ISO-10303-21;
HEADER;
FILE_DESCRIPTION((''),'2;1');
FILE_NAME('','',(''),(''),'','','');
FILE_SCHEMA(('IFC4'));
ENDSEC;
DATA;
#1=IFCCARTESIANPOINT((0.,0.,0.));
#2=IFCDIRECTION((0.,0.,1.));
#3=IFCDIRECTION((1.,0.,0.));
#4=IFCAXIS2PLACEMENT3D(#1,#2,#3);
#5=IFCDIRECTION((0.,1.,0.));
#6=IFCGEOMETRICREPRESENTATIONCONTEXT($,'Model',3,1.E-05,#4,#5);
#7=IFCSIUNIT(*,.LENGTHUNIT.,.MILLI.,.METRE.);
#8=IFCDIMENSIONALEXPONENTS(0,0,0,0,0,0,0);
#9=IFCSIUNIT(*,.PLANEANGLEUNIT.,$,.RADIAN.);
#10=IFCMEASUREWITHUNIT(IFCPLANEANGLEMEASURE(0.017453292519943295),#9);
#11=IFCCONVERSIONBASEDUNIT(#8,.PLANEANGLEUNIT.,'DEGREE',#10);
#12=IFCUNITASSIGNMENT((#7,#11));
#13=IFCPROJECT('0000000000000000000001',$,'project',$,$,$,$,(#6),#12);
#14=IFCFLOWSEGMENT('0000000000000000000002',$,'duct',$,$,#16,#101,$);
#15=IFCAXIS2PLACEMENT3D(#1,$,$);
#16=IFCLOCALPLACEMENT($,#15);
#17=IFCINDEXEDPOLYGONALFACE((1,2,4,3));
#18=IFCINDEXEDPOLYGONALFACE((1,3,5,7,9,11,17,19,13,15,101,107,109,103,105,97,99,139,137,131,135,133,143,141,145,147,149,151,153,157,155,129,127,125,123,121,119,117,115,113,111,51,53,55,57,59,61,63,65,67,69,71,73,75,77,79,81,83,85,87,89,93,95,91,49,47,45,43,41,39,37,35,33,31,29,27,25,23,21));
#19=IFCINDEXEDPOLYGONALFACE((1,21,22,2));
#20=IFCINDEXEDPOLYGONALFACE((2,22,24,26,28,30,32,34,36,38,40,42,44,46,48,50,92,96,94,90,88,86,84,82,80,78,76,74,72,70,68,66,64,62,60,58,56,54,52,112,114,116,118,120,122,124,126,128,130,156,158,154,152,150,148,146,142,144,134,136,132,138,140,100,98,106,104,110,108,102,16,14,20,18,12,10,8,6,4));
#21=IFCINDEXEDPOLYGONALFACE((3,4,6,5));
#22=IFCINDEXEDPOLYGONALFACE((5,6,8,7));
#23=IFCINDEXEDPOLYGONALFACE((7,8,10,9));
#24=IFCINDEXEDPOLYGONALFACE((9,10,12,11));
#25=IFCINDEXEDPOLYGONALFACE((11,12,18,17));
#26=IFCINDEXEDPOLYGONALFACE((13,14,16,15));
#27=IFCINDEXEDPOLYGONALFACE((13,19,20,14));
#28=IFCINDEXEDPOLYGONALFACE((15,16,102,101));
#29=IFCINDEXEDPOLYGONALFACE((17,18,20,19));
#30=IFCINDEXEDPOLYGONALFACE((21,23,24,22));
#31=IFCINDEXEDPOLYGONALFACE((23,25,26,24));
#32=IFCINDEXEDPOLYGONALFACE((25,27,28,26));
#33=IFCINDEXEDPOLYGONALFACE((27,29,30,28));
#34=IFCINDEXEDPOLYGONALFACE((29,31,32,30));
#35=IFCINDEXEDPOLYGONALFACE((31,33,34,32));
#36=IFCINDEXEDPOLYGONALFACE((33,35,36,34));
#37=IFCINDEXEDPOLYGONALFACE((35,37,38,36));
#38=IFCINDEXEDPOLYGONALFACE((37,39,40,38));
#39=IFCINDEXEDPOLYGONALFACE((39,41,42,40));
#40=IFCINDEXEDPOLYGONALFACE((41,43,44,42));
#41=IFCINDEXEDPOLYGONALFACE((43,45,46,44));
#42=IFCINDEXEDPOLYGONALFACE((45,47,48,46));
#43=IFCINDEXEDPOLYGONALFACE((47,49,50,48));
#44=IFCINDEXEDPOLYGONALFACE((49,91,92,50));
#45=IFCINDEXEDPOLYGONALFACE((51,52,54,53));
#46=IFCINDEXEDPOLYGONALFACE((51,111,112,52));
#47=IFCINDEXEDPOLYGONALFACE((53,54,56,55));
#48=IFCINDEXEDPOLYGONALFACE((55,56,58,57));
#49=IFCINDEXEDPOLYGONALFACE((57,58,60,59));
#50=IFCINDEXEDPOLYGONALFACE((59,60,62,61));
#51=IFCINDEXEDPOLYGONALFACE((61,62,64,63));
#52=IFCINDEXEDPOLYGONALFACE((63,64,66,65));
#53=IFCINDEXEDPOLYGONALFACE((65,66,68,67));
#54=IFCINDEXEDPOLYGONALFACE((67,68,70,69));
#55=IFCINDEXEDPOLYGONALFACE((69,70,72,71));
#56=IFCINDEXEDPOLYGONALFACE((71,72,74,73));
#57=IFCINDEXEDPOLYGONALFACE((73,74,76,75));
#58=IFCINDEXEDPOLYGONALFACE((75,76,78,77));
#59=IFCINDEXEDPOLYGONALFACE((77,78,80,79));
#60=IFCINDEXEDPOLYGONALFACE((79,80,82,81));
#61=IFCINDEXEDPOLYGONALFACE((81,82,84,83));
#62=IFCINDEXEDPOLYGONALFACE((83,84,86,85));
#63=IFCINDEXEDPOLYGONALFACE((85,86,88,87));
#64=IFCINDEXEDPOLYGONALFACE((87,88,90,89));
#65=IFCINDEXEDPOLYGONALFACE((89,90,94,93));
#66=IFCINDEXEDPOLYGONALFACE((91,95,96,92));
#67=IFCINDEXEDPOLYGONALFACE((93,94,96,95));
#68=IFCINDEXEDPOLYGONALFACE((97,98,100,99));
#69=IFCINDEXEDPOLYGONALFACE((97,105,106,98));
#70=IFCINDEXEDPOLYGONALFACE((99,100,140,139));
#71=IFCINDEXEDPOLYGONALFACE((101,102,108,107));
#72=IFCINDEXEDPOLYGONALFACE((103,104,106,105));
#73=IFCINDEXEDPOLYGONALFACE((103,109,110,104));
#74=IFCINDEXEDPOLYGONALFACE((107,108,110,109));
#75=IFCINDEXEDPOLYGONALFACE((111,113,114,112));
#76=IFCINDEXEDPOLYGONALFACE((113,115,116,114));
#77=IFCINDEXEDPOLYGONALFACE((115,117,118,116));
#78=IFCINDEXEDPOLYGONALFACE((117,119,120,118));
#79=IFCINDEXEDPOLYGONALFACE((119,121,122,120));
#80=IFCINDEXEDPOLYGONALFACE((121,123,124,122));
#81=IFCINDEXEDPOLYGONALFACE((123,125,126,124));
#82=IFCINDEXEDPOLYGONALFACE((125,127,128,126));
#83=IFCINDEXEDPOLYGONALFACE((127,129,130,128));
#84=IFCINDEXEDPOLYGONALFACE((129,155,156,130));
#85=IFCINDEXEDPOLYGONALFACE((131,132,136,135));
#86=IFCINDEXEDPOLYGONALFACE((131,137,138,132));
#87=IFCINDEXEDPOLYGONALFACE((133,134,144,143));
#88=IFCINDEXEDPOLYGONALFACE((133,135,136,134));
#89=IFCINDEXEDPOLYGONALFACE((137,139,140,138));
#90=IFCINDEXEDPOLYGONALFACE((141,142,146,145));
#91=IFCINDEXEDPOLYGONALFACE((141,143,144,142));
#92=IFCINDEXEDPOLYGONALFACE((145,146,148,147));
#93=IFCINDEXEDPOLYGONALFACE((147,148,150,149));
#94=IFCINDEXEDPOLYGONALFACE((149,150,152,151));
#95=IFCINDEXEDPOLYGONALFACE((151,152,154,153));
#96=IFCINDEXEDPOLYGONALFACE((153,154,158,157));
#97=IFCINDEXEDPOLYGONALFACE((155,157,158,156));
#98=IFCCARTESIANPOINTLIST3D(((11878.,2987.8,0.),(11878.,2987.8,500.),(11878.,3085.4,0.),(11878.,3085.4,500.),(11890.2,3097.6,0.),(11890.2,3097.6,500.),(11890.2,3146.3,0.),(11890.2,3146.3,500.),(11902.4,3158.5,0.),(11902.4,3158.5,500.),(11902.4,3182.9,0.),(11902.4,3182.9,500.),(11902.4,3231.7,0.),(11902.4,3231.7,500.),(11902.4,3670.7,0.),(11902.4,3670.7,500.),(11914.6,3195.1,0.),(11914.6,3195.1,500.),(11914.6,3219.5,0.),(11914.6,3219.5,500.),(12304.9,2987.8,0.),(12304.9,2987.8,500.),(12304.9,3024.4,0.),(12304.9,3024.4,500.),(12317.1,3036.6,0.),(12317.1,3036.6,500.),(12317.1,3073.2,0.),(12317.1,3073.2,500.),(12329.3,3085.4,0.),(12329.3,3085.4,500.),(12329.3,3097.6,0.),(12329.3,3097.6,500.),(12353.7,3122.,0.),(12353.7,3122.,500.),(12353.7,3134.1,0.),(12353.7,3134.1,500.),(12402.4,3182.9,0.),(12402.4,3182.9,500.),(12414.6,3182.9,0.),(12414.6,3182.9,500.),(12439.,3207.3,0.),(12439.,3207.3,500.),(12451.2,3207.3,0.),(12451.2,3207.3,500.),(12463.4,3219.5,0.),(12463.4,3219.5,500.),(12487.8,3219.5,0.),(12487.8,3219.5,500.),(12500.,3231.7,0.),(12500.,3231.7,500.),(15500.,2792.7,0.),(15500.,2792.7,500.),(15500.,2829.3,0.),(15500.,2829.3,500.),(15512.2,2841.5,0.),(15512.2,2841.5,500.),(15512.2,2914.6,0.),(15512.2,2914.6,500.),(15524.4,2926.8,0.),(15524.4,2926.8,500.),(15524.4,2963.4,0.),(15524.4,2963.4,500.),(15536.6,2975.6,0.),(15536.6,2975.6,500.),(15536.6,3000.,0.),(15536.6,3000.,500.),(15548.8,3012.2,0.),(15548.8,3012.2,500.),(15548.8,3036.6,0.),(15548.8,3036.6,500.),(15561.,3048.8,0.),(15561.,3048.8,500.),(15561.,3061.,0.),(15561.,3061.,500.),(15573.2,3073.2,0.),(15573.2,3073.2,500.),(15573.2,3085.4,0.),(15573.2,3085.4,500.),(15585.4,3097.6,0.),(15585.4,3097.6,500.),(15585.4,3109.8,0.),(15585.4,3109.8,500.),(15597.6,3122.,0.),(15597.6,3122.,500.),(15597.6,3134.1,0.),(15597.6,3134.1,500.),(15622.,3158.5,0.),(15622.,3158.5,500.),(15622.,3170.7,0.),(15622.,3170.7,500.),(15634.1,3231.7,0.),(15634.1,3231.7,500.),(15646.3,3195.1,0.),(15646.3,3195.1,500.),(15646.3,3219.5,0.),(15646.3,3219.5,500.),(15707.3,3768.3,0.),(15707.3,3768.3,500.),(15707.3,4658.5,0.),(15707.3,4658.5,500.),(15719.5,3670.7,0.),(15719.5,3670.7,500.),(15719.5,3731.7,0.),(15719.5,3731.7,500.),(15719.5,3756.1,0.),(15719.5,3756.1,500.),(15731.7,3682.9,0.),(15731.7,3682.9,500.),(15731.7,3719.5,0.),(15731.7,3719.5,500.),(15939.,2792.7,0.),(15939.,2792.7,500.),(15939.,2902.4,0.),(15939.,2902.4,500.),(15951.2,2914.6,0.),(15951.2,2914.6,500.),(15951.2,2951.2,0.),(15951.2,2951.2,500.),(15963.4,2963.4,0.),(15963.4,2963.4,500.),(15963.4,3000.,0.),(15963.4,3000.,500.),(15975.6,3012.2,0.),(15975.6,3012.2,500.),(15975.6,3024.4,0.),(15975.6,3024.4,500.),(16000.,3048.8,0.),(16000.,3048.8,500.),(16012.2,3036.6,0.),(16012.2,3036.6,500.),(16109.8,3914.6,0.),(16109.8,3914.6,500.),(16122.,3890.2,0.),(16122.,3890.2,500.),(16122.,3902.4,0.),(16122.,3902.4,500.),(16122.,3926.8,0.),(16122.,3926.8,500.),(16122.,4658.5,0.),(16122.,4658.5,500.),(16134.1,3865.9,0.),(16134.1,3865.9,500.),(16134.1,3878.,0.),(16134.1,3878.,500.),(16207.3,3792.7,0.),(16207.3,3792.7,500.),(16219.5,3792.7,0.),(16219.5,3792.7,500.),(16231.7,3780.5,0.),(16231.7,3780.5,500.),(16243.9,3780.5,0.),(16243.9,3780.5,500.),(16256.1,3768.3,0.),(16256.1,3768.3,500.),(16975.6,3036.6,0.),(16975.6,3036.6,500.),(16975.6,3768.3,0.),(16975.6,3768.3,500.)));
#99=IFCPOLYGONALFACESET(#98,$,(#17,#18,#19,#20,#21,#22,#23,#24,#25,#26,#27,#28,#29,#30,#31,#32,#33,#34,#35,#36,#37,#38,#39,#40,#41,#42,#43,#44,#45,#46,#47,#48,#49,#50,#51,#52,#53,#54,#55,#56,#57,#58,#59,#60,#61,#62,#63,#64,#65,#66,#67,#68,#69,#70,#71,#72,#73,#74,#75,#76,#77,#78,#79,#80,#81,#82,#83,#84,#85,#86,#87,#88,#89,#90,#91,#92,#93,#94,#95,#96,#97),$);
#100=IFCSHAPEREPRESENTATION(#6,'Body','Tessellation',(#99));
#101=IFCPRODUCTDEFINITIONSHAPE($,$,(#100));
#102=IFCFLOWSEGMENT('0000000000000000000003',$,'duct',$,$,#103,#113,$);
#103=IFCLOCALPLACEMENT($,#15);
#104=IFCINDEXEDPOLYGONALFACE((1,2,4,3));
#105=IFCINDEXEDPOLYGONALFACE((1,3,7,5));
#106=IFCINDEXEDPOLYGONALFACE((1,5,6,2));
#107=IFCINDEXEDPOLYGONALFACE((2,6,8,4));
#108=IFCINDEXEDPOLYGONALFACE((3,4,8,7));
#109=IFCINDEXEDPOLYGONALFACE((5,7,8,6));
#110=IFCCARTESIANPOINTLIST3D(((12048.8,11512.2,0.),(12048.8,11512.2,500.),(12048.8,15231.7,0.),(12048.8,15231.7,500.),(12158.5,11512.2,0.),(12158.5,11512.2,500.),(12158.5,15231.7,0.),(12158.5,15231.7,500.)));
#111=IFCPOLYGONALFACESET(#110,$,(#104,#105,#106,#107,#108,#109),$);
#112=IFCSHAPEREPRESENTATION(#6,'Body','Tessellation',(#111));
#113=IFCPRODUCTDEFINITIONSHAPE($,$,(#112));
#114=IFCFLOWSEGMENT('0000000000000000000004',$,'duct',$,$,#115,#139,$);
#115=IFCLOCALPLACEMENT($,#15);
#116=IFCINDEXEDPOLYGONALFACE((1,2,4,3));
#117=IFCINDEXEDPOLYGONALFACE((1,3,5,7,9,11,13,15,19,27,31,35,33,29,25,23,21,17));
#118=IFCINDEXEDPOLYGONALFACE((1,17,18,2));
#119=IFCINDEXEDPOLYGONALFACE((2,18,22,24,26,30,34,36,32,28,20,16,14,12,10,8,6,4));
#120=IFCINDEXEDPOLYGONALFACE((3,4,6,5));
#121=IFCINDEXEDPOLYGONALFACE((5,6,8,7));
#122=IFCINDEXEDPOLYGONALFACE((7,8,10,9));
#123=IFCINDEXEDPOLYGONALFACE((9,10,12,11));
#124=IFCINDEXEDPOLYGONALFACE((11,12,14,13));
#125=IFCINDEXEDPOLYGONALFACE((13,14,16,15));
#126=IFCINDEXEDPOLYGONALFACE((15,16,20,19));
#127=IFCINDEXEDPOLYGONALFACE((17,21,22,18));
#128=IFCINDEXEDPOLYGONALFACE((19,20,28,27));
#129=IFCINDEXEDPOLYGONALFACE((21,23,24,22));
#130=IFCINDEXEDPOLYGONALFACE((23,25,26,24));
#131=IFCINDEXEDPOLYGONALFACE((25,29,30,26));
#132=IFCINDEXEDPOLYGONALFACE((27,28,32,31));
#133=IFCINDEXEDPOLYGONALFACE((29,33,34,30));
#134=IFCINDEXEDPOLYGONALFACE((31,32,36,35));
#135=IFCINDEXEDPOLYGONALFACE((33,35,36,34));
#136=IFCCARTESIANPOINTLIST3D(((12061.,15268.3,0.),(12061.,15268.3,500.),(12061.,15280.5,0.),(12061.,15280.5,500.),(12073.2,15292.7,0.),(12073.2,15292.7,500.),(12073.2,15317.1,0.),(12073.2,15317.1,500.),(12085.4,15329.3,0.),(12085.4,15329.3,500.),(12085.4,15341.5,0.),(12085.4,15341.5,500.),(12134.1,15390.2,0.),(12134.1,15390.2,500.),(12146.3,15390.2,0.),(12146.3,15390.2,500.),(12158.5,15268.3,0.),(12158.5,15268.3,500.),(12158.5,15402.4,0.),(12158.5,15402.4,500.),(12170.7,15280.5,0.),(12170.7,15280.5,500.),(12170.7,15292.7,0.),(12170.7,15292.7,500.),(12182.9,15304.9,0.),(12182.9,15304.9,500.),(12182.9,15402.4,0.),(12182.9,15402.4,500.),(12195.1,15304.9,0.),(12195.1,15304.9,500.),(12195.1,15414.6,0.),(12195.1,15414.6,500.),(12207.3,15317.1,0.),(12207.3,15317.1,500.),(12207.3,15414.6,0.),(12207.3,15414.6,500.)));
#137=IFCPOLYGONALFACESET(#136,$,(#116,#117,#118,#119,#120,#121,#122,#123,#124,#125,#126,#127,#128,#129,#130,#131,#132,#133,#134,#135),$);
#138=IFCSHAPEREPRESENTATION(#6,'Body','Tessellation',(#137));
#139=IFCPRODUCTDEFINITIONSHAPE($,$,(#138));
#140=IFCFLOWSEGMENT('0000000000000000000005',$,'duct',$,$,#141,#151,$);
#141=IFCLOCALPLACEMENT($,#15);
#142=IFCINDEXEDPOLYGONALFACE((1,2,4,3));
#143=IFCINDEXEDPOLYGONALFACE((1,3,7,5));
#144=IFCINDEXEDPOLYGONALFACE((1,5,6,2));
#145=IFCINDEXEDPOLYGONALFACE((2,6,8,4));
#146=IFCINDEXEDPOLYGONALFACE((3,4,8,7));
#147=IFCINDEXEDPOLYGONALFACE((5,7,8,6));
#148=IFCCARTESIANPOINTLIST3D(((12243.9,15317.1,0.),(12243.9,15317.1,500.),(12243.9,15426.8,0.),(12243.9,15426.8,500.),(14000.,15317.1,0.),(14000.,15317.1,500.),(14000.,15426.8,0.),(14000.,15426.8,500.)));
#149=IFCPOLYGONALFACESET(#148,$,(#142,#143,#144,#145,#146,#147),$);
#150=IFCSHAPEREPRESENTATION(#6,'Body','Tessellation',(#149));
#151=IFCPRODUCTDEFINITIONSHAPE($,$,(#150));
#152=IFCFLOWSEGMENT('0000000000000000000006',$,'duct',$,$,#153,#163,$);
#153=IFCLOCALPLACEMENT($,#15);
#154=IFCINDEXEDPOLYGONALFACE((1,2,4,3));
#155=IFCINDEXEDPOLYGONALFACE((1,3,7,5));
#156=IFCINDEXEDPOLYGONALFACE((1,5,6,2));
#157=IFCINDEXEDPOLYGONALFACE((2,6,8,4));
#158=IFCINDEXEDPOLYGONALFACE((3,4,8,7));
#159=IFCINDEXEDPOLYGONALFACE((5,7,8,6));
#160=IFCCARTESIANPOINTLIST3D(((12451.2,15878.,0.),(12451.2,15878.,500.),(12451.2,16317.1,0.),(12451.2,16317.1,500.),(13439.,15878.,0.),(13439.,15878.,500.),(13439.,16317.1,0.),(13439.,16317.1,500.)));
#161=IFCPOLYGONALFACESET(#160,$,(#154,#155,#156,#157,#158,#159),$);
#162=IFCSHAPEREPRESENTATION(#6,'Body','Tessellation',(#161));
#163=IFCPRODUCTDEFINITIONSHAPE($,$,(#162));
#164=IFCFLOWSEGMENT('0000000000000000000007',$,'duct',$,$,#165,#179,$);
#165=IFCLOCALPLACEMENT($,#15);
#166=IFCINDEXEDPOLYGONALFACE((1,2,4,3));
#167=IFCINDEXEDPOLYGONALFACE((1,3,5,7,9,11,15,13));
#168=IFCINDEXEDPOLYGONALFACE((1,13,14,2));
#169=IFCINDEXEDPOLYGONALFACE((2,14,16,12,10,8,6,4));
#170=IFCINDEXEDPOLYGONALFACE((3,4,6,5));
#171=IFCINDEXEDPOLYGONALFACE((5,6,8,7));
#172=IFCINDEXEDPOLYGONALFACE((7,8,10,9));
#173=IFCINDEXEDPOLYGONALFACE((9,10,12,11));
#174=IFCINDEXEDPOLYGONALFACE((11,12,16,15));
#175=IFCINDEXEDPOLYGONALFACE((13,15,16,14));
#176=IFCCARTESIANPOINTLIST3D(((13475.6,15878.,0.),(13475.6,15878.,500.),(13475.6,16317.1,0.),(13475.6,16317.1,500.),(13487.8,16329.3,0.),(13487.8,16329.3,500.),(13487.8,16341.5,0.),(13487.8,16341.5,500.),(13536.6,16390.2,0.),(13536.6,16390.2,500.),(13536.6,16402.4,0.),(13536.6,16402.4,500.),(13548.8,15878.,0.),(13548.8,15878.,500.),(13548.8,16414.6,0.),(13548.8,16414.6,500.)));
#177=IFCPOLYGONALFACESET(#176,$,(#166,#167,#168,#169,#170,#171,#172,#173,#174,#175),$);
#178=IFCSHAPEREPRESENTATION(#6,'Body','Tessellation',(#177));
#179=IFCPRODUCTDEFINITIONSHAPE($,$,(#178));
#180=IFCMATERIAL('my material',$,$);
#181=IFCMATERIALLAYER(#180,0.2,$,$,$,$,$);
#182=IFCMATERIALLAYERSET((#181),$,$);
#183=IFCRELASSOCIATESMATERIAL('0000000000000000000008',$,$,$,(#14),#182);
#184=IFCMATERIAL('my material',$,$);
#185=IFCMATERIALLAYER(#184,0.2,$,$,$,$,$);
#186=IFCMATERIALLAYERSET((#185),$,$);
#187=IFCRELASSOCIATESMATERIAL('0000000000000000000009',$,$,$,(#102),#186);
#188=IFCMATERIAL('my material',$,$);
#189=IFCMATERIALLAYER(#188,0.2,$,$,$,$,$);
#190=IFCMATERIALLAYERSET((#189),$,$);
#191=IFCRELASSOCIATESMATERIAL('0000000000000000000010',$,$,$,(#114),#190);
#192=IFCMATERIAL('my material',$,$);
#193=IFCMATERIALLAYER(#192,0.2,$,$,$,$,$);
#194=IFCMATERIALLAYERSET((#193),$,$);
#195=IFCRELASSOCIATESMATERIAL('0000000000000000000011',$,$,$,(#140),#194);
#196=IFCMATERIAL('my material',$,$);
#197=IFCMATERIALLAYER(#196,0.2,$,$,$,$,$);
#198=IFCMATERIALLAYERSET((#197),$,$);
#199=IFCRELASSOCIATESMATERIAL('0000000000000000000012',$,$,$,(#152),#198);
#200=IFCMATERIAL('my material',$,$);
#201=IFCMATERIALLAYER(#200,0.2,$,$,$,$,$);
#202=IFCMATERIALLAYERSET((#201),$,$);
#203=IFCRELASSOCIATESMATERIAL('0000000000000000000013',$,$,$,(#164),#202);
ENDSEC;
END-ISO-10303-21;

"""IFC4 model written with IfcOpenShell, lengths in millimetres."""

from ifc_helpers import new_model, entity, si_unit, converted_unit, direction, origin_with_axes, place, context, project, polyline, outline, extrude, material, layer, layer_set, layer_usage, element, save


model = new_model("IFC4")

# Units and contexts
model_context = context("Model", 3, precision=1e-05, world=origin_with_axes(), true_north=direction((0.0, 1.0, 0.0)))
ifc_project = project(units=[si_unit("LENGTHUNIT", "METRE", prefix="MILLI"), converted_unit("PLANEANGLEUNIT", "DEGREE", entity("IfcPlaneAngleMeasure", 0.017453292519943295), si_unit("PLANEANGLEUNIT", "RADIAN"), dimensions=[0, 0, 0, 0, 0, 0, 0])], contexts=[model_context])

# Flow segments
ifc_material_1 = material(Name="my material")
ifc_layer_1 = layer(ifc_material_1, 0.2)
ifc_layer_set_1 = layer_set([ifc_layer_1])
ifc_layer_usage_1 = layer_usage(ifc_layer_set_1, "AXIS2", "POSITIVE", -0.1)
flow_segment_1_placement = place(None, origin_with_axes())
element("IfcFlowSegment", 1, at=flow_segment_1_placement, material=ifc_layer_usage_1, Name="duct", context=model_context, shape_type="SweptSolid", body=[
    extrude(outline(polyline([(11878.0, 2987.8), (12304.9, 2987.8), (12304.9, 3024.4), (12317.1, 3036.6), (12317.1, 3073.2), (12329.3, 3085.4), (12329.3, 3097.6), (12353.7, 3122.0), (12353.7, 3134.1), (12402.4, 3182.9), (12414.6, 3182.9), (12439.0, 3207.3), (12451.2, 3207.3), (12463.4, 3219.5), (12487.8, 3219.5), (12500.0, 3231.7), (15634.1, 3231.7), (15646.3, 3219.5), (15646.3, 3195.1), (15622.0, 3170.7), (15622.0, 3158.5), (15597.6, 3134.1), (15597.6, 3122.0), (15585.4, 3109.8), (15585.4, 3097.6), (15573.2, 3085.4), (15573.2, 3073.2), (15561.0, 3061.0), (15561.0, 3048.8), (15548.8, 3036.6), (15548.8, 3012.2), (15536.6, 3000.0), (15536.6, 2975.6), (15524.4, 2963.4), (15524.4, 2926.8), (15512.2, 2914.6), (15512.2, 2841.5), (15500.0, 2829.3), (15500.0, 2792.7), (15939.0, 2792.7), (15939.0, 2902.4), (15951.2, 2914.6), (15951.2, 2951.2), (15963.4, 2963.4), (15963.4, 3000.0), (15975.6, 3012.2), (15975.6, 3024.4), (16000.0, 3048.8), (16012.2, 3036.6), (16975.6, 3036.6), (16975.6, 3768.3), (16256.1, 3768.3), (16243.9, 3780.5), (16231.7, 3780.5), (16219.5, 3792.7), (16207.3, 3792.7), (16134.1, 3865.9), (16134.1, 3878.0), (16122.0, 3890.2), (16122.0, 3902.4), (16109.8, 3914.6), (16122.0, 3926.8), (16122.0, 4658.5), (15707.3, 4658.5), (15707.3, 3768.3), (15719.5, 3756.1), (15719.5, 3731.7), (15731.7, 3719.5), (15731.7, 3682.9), (15719.5, 3670.7), (11902.4, 3670.7), (11902.4, 3231.7), (11914.6, 3219.5), (11914.6, 3195.1), (11902.4, 3182.9), (11902.4, 3158.5), (11890.2, 3146.3), (11890.2, 3097.6), (11878.0, 3085.4), (11878.0, 2987.8)])), origin_with_axes(), (0.0, 0.0, 1.0), 500.0),
])
ifc_material_2 = material(Name="my material")
ifc_layer_2 = layer(ifc_material_2, 0.2)
ifc_layer_set_2 = layer_set([ifc_layer_2])
ifc_layer_usage_2 = layer_usage(ifc_layer_set_2, "AXIS2", "POSITIVE", -0.1)
flow_segment_2_placement = place(None, origin_with_axes())
element("IfcFlowSegment", 2, at=flow_segment_2_placement, material=ifc_layer_usage_2, Name="duct", context=model_context, shape_type="SweptSolid", body=[
    extrude(outline(polyline([(12048.8, 11512.2), (12158.5, 11512.2), (12158.5, 15231.7), (12048.8, 15231.7), (12048.8, 11512.2)])), origin_with_axes(), (0.0, 0.0, 1.0), 500.0),
])
ifc_material_3 = material(Name="my material")
ifc_layer_3 = layer(ifc_material_3, 0.2)
ifc_layer_set_3 = layer_set([ifc_layer_3])
ifc_layer_usage_3 = layer_usage(ifc_layer_set_3, "AXIS2", "POSITIVE", -0.1)
flow_segment_3_placement = place(None, origin_with_axes())
element("IfcFlowSegment", 3, at=flow_segment_3_placement, material=ifc_layer_usage_3, Name="duct", context=model_context, shape_type="SweptSolid", body=[
    extrude(outline(polyline([(12061.0, 15268.3), (12158.5, 15268.3), (12170.7, 15280.5), (12170.7, 15292.7), (12182.9, 15304.9), (12195.1, 15304.9), (12207.3, 15317.1), (12207.3, 15414.6), (12195.1, 15414.6), (12182.9, 15402.4), (12158.5, 15402.4), (12146.3, 15390.2), (12134.1, 15390.2), (12085.4, 15341.5), (12085.4, 15329.3), (12073.2, 15317.1), (12073.2, 15292.7), (12061.0, 15280.5), (12061.0, 15268.3)])), origin_with_axes(), (0.0, 0.0, 1.0), 500.0),
])
ifc_material_4 = material(Name="my material")
ifc_layer_4 = layer(ifc_material_4, 0.2)
ifc_layer_set_4 = layer_set([ifc_layer_4])
ifc_layer_usage_4 = layer_usage(ifc_layer_set_4, "AXIS2", "POSITIVE", -0.1)
flow_segment_4_placement = place(None, origin_with_axes())
element("IfcFlowSegment", 4, at=flow_segment_4_placement, material=ifc_layer_usage_4, Name="duct", context=model_context, shape_type="SweptSolid", body=[
    extrude(outline(polyline([(12243.9, 15317.1), (14000.0, 15317.1), (14000.0, 15426.8), (12243.9, 15426.8), (12243.9, 15317.1)])), origin_with_axes(), (0.0, 0.0, 1.0), 500.0),
])
ifc_material_5 = material(Name="my material")
ifc_layer_5 = layer(ifc_material_5, 0.2)
ifc_layer_set_5 = layer_set([ifc_layer_5])
ifc_layer_usage_5 = layer_usage(ifc_layer_set_5, "AXIS2", "POSITIVE", -0.1)
flow_segment_5_placement = place(None, origin_with_axes())
element("IfcFlowSegment", 5, at=flow_segment_5_placement, material=ifc_layer_usage_5, Name="duct", context=model_context, shape_type="SweptSolid", body=[
    extrude(outline(polyline([(12451.2, 15878.0), (13439.0, 15878.0), (13439.0, 16317.1), (12451.2, 16317.1), (12451.2, 15878.0)])), origin_with_axes(), (0.0, 0.0, 1.0), 500.0),
])
ifc_material_6 = material(Name="my material")
ifc_layer_6 = layer(ifc_material_6, 0.2)
ifc_layer_set_6 = layer_set([ifc_layer_6])
ifc_layer_usage_6 = layer_usage(ifc_layer_set_6, "AXIS2", "POSITIVE", -0.1)
flow_segment_6_placement = place(None, origin_with_axes())
element("IfcFlowSegment", 6, at=flow_segment_6_placement, material=ifc_layer_usage_6, Name="duct", context=model_context, shape_type="SweptSolid", body=[
    extrude(outline(polyline([(13475.6, 15878.0), (13548.8, 15878.0), (13548.8, 16414.6), (13536.6, 16402.4), (13536.6, 16390.2), (13487.8, 16341.5), (13487.8, 16329.3), (13475.6, 16317.1), (13475.6, 15878.0)])), origin_with_axes(), (0.0, 0.0, 1.0), 500.0),
])

save(model, "model.ifc")
